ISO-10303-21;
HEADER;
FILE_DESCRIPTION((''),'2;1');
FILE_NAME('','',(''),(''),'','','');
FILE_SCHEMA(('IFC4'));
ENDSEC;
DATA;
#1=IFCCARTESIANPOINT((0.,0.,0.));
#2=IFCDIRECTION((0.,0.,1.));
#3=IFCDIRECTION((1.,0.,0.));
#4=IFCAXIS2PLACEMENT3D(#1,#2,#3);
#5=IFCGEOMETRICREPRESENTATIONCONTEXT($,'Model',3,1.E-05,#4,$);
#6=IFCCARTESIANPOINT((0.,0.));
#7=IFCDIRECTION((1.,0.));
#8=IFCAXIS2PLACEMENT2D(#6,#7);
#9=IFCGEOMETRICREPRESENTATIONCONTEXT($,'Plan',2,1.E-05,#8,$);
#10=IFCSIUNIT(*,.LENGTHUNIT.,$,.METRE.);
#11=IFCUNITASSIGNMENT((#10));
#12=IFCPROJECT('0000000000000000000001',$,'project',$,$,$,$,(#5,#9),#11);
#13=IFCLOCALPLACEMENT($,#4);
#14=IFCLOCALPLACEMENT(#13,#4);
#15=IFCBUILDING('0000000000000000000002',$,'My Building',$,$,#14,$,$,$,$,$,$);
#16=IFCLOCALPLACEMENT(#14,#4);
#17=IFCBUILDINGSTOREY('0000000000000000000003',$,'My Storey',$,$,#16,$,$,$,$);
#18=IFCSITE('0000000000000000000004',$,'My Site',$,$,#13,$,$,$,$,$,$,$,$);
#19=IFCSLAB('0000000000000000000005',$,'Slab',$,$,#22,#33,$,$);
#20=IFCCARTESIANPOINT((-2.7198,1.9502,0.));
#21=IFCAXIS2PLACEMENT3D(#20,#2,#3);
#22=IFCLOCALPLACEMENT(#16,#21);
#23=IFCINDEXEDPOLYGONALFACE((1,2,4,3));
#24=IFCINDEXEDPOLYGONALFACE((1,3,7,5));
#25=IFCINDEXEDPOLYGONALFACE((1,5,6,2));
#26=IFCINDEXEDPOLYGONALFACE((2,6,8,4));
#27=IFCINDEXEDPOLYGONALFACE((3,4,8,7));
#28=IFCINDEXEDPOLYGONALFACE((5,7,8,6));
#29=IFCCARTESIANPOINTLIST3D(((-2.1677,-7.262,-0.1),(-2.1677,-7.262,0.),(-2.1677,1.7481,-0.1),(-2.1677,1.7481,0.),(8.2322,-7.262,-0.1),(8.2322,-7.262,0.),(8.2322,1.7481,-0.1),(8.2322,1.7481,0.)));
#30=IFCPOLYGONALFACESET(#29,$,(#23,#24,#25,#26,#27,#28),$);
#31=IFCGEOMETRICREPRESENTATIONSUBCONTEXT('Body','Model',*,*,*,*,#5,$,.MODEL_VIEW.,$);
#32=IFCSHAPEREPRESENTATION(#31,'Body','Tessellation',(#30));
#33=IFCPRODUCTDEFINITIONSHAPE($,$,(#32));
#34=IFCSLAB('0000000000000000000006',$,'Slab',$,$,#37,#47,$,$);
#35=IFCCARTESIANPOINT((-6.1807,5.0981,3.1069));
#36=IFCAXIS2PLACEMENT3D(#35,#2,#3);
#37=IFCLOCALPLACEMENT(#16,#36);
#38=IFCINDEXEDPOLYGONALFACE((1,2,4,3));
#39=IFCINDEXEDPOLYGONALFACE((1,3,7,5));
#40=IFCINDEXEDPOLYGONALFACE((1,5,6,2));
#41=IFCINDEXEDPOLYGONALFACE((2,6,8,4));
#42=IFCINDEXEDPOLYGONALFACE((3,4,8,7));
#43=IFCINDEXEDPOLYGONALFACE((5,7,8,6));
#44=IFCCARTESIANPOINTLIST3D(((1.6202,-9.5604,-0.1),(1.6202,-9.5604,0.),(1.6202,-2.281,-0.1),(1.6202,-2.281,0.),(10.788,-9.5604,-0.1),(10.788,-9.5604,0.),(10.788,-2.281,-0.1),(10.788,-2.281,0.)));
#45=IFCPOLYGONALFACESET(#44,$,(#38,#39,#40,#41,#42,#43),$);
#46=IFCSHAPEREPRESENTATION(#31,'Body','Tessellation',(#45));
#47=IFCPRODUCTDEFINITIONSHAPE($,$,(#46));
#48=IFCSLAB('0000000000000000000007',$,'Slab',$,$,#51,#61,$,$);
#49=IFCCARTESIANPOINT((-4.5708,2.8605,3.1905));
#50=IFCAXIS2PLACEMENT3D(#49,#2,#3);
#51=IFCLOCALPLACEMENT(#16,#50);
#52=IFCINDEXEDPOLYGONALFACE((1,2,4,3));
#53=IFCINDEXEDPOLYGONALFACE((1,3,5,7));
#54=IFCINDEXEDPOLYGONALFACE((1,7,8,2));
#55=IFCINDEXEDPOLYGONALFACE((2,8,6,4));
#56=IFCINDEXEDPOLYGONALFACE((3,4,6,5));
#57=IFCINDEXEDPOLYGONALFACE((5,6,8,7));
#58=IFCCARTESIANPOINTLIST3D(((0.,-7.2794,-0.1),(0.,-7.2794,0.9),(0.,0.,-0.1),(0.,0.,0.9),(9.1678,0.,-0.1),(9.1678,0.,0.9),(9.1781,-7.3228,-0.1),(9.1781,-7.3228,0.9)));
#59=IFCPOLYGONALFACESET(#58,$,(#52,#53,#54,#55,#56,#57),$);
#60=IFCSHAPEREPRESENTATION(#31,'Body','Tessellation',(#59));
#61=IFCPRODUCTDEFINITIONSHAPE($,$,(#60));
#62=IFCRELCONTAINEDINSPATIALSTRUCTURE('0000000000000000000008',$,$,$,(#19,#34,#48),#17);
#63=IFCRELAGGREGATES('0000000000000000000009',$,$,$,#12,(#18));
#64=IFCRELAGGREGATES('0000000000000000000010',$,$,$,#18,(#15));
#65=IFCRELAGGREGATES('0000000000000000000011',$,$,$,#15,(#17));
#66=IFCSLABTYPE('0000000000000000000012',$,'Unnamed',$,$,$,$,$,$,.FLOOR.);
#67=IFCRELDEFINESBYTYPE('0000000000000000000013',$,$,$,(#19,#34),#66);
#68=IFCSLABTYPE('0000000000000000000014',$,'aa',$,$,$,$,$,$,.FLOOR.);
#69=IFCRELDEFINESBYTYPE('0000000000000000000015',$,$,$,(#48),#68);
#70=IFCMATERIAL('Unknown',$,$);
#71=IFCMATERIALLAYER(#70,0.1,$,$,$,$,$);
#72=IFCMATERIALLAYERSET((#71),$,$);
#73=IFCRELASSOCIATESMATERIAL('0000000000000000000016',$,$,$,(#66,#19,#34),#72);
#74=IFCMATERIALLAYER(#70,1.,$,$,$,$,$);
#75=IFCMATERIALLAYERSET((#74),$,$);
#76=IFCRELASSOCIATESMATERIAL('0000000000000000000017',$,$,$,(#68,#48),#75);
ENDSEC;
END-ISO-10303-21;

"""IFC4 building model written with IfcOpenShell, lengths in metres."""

from ifc_helpers import new_model, si_unit, frame, origin_with_axes, origin_2d_with_axis, place, context, subcontext, project, spatial, indexed_curve, outline, extrude, material, layer, layer_set, layer_usage, type_object, element, save


model = new_model("IFC4")

# Units and contexts
model_context = context("Model", 3, precision=1e-05, world=origin_with_axes())
plan_context = context("Plan", 2, precision=1e-05, world=origin_2d_with_axis())
body_context_1 = subcontext(model_context, "Body", "Model", "MODEL_VIEW")
ifc_project = project(units=[si_unit("LENGTHUNIT", "METRE")], contexts=[model_context, plan_context])

# Site, building, storey
site_placement = place(None, origin_with_axes())
site = spatial("IfcSite", under=ifc_project, at=site_placement, Name="My Site")
building_placement = place(site_placement, origin_with_axes())
building = spatial("IfcBuilding", under=site, at=building_placement, Name="My Building")
storey_placement = place(building_placement, origin_with_axes())
storey = spatial("IfcBuildingStorey", under=building, at=storey_placement, Name="My Storey")

# Shared definitions
ifc_material = material(Name="Unknown")

# Slabs
ifc_layer_1 = layer(ifc_material, 0.1)
ifc_layer_set_1 = layer_set([ifc_layer_1])
ifc_layer_usage_1 = layer_usage(ifc_layer_set_1, "AXIS3", "POSITIVE", -0.1)
slab_type_1 = type_object("IfcSlabType", Name="Unnamed", PredefinedType="FLOOR", material=ifc_layer_set_1)
slab_1_placement = place(storey_placement, frame((-2.7198, 1.9502, 0.0), z_axis=(0.0, 0.0, 1.0), x_axis=(1.0, 0.0, 0.0)))
element("IfcSlab", 1, at=slab_1_placement, inside=storey, type_object=slab_type_1, material=ifc_layer_usage_1, Name="Slab", context=body_context_1, shape_type="SweptSolid", body=[
    extrude(outline(indexed_curve([(-2.1677, 1.7481), (-2.1677, -7.262), (8.2322, -7.262), (8.2322, 1.7481), (-2.1677, 1.7481)])), frame((0.0, 0.0, -0.1), z_axis=(0.0, 0.0, 1.0), x_axis=(1.0, 0.0, 0.0)), (0.0, 0.0, 1.0), 0.1),
])
ifc_layer_usage_2 = layer_usage(ifc_layer_set_1, "AXIS3", "POSITIVE", -0.1)
slab_2_placement = place(storey_placement, frame((-6.1807, 5.0981, 3.1069), z_axis=(0.0, 0.0, 1.0), x_axis=(1.0, 0.0, 0.0)))
element("IfcSlab", 2, at=slab_2_placement, inside=storey, type_object=slab_type_1, material=ifc_layer_usage_2, Name="Slab", context=body_context_1, shape_type="SweptSolid", body=[
    extrude(outline(indexed_curve([(10.788, -2.281), (10.788, -9.5604), (1.6202, -9.5604), (1.6202, -2.281), (10.788, -2.281)])), frame((0.0, 0.0, -0.1), z_axis=(0.0, 0.0, 1.0), x_axis=(1.0, 0.0, 0.0)), (0.0, 0.0, 1.0), 0.1),
])
ifc_layer_2 = layer(ifc_material, 1.0)
ifc_layer_set_2 = layer_set([ifc_layer_2])
ifc_layer_usage_3 = layer_usage(ifc_layer_set_2, "AXIS3", "POSITIVE", -0.1)
slab_type_2 = type_object("IfcSlabType", Name="aa", PredefinedType="FLOOR", material=ifc_layer_set_2)
slab_3_placement = place(storey_placement, frame((-4.5708, 2.8605, 3.1905), z_axis=(0.0, 0.0, 1.0), x_axis=(1.0, 0.0, 0.0)))
element("IfcSlab", 3, at=slab_3_placement, inside=storey, type_object=slab_type_2, material=ifc_layer_usage_3, Name="Slab", context=body_context_1, shape_type="SweptSolid", body=[
    extrude(outline(indexed_curve([(0.0, 0.0), (0.0, -7.2794), (9.1781, -7.3228), (9.1678, 0.0), (0.0, 0.0)])), frame((0.0, 0.0, -0.1), z_axis=(0.0, 0.0, 1.0), x_axis=(1.0, 0.0, 0.0)), (0.0, 0.0, 1.0), 1.0),
])

save(model, "model.ifc")
